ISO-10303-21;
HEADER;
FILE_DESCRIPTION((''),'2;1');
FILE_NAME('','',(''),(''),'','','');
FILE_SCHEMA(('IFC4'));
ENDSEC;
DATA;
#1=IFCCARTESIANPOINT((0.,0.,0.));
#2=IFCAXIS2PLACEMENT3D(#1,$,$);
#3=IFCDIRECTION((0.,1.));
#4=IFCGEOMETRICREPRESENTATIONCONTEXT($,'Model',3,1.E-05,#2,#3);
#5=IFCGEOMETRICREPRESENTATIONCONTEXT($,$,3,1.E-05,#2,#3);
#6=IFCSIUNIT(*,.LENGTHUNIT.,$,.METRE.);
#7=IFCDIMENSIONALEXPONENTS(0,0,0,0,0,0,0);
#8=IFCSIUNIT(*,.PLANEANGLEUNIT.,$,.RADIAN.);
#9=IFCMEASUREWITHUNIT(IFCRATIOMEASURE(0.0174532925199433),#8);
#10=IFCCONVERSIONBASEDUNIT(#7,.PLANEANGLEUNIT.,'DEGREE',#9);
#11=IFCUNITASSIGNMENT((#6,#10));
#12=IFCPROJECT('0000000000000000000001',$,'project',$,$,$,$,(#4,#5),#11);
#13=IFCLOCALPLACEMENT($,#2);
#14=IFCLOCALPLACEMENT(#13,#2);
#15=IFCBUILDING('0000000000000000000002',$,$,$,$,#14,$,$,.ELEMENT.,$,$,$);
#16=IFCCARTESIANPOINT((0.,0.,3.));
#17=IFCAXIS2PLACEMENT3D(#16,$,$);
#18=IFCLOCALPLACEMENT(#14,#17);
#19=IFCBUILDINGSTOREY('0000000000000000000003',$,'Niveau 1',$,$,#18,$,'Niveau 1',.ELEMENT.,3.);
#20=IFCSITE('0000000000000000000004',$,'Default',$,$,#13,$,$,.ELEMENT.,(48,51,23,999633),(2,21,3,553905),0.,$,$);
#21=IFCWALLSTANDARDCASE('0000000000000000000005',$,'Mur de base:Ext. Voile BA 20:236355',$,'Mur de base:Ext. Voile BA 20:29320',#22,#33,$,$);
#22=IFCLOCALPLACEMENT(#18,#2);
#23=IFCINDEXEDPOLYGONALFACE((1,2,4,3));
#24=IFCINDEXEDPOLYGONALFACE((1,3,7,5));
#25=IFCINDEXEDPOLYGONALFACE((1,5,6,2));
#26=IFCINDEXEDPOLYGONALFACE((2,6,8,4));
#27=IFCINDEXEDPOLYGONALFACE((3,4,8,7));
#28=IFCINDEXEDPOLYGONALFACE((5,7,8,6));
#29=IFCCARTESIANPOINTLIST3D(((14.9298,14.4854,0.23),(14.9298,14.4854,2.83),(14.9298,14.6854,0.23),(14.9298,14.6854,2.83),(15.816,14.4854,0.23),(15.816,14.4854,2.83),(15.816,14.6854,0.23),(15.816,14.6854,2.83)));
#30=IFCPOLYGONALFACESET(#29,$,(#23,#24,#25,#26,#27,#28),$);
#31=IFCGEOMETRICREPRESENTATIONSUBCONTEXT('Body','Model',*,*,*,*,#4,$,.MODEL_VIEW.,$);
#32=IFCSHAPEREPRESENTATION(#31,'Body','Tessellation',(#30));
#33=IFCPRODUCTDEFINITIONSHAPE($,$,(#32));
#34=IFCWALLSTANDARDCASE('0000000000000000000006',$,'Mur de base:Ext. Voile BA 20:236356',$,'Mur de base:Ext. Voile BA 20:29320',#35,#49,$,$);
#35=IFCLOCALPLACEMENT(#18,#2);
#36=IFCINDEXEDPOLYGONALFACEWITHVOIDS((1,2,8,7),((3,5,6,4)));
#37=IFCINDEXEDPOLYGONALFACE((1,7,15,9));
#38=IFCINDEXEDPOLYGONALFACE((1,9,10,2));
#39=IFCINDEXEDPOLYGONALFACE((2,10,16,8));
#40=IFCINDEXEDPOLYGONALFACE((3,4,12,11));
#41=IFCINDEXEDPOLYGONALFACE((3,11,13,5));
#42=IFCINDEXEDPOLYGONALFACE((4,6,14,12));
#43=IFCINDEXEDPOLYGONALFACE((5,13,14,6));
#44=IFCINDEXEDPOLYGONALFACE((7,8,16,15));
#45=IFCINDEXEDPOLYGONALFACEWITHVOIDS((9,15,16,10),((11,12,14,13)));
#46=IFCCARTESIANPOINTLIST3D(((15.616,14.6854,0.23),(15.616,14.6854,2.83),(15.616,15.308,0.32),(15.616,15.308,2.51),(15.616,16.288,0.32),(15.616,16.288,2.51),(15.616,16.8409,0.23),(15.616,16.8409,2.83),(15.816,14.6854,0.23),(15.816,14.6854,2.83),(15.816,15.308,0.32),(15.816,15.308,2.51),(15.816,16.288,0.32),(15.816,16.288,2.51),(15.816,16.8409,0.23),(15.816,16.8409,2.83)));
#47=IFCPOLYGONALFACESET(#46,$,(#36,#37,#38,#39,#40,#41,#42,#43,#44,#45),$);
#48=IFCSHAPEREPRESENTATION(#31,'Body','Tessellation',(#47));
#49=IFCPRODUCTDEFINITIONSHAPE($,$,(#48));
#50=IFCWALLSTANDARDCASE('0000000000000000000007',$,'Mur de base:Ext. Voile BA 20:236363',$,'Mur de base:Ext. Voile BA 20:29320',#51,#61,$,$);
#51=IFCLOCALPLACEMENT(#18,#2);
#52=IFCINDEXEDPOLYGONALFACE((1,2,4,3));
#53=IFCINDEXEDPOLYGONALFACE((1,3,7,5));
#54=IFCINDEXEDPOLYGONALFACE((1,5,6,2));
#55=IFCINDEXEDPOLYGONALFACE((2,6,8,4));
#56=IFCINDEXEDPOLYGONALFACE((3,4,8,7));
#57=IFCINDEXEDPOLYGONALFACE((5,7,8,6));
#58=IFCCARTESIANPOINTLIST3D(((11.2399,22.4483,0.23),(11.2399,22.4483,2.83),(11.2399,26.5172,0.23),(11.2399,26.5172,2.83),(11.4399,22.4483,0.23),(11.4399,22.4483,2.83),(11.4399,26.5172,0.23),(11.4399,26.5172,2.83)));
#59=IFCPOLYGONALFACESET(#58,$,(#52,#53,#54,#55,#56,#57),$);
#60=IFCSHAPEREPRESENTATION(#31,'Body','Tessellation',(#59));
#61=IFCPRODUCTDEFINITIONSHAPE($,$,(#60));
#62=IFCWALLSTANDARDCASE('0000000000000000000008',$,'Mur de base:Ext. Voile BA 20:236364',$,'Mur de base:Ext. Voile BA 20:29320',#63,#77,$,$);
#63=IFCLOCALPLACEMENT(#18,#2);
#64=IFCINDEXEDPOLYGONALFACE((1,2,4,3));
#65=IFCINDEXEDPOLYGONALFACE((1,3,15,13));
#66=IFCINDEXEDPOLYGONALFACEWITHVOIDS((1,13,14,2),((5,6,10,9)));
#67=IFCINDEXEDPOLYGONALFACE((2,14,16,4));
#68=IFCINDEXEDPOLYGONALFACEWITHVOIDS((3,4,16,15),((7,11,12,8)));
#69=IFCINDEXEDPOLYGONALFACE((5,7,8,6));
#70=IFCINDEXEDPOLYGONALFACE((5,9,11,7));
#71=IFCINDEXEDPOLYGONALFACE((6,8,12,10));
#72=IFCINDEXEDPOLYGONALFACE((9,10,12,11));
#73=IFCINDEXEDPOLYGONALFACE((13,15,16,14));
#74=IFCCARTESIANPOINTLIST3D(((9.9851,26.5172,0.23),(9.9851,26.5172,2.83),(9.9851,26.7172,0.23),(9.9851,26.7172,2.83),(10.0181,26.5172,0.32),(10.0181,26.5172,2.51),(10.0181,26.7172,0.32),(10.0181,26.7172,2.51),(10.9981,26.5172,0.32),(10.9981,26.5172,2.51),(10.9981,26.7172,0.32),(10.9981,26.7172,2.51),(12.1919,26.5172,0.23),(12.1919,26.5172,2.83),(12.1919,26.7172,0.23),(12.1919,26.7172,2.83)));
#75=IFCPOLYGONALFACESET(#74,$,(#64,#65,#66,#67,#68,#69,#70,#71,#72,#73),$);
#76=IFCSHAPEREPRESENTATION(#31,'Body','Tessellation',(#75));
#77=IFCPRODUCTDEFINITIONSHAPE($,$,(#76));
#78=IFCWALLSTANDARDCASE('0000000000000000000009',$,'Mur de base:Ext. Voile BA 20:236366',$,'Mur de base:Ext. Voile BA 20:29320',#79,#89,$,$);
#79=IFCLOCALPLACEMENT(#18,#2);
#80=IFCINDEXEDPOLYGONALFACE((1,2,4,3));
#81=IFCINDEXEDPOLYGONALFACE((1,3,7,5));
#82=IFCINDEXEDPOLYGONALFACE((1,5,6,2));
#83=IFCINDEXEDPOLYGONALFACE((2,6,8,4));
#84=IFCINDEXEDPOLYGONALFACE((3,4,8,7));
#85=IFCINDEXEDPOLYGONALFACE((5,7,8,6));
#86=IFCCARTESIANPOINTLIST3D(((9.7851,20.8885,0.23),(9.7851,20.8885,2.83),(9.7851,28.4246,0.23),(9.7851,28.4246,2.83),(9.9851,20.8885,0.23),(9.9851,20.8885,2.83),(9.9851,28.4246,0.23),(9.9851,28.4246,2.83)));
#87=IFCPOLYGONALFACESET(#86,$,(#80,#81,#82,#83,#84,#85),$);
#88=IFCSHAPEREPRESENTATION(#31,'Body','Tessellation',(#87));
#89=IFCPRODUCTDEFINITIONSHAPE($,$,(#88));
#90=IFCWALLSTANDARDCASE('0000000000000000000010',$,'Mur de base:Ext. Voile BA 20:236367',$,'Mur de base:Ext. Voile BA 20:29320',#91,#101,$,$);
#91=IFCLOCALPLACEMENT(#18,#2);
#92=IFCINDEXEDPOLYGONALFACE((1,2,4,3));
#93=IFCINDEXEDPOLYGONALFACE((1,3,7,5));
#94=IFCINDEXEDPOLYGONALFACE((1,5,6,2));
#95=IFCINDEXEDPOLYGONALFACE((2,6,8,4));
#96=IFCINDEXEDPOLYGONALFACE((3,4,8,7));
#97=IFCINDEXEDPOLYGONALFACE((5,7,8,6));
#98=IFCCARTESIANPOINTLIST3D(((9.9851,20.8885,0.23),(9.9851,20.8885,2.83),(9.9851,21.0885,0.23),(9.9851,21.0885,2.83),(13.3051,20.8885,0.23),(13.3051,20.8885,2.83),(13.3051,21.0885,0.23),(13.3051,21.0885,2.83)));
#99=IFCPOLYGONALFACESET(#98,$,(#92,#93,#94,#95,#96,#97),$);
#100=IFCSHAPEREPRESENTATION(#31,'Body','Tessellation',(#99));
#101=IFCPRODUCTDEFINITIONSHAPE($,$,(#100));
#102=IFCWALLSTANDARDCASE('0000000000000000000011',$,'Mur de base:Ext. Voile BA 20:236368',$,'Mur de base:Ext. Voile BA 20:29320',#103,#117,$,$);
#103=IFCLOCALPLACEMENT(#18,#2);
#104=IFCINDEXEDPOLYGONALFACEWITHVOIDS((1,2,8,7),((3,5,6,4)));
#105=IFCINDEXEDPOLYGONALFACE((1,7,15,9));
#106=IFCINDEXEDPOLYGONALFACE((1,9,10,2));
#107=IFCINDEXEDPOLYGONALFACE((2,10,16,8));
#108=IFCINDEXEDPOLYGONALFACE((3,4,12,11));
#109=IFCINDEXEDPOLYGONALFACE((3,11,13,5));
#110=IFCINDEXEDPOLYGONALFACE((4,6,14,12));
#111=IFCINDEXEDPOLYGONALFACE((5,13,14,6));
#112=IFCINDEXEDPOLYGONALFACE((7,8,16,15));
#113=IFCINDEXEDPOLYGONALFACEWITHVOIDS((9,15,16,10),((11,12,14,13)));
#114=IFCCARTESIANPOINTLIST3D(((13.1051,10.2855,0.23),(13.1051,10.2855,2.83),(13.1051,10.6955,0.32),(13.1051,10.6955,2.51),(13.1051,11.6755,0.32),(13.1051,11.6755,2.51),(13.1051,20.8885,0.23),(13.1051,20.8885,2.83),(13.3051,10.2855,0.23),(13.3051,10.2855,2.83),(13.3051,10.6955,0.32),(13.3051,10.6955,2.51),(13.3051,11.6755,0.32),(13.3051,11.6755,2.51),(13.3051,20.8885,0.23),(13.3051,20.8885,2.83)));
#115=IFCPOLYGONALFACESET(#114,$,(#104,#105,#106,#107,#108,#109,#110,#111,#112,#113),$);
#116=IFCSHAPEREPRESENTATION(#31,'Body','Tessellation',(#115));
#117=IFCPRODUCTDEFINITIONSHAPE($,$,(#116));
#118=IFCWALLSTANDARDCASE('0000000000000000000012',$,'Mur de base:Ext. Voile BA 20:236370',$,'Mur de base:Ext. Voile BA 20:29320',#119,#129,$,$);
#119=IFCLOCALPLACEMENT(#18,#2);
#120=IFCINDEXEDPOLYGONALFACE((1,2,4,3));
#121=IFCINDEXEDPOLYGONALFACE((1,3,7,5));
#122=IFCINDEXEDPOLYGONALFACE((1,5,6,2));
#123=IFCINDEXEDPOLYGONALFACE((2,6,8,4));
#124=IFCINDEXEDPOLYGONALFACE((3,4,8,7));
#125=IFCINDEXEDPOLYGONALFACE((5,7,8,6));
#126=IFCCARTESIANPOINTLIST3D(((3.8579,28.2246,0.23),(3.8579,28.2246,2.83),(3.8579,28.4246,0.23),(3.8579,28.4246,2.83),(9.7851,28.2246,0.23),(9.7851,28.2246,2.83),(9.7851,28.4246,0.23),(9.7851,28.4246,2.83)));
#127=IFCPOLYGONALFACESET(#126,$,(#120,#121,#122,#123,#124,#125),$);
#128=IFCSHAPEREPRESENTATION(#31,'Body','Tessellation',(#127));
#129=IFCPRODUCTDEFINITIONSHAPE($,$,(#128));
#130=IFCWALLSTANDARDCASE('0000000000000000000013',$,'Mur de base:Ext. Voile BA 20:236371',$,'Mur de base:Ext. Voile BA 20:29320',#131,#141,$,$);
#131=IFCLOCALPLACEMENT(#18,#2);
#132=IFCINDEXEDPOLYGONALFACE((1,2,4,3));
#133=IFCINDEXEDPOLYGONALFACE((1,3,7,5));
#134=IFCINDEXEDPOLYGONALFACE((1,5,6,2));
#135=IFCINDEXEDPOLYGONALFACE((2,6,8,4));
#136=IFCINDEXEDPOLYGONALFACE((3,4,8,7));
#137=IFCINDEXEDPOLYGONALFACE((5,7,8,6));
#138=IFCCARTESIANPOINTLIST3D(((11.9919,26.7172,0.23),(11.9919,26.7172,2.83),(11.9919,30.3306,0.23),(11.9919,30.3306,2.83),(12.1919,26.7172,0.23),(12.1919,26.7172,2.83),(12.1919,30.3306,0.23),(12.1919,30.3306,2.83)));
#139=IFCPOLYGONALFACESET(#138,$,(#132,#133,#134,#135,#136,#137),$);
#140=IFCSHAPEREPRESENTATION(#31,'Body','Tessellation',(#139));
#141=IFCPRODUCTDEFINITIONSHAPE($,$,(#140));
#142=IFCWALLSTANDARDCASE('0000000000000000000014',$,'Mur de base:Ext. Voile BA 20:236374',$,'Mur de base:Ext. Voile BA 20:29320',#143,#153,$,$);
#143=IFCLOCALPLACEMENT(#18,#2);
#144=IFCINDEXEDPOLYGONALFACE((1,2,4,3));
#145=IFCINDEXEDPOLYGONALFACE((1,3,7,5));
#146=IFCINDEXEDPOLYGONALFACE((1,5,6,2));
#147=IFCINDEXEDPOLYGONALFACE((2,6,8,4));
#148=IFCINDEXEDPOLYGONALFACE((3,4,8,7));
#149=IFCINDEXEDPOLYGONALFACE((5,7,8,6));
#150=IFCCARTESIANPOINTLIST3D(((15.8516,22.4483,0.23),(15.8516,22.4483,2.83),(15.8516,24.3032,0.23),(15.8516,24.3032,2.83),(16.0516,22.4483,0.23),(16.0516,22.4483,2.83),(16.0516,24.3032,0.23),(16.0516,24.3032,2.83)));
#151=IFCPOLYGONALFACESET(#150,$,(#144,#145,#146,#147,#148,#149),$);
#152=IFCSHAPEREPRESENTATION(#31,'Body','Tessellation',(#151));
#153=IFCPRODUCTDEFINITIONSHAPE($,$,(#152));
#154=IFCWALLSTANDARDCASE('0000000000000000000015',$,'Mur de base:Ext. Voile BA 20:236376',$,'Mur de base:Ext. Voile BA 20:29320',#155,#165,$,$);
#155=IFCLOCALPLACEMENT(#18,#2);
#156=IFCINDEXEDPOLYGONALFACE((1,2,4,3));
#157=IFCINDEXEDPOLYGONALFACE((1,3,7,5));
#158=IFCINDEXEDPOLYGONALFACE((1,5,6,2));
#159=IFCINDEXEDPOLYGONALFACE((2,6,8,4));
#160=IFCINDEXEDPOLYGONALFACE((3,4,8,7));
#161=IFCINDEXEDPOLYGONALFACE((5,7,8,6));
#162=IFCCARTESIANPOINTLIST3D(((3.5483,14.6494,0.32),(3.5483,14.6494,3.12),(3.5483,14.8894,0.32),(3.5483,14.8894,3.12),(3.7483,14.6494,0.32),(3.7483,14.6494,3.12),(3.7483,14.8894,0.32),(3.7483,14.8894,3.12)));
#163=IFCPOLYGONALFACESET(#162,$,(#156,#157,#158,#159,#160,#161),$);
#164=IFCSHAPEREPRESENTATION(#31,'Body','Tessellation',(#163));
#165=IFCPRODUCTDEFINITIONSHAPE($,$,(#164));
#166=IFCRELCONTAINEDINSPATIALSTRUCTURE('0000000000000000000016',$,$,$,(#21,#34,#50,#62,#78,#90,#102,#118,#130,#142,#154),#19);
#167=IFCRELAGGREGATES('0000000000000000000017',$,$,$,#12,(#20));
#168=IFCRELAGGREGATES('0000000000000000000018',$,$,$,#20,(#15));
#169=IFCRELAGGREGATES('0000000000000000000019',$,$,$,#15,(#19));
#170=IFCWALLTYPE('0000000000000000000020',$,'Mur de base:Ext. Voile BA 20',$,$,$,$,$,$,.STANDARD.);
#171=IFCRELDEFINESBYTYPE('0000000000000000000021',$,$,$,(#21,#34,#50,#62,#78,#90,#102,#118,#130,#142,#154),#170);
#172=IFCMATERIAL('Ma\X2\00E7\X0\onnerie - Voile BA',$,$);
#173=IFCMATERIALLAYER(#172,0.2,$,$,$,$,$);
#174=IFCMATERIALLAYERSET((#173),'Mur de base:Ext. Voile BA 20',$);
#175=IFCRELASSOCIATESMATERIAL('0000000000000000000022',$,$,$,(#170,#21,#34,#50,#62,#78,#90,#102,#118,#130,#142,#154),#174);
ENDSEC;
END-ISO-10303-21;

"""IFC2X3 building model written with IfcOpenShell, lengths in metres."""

from ifc_helpers import new_model, entity, si_unit, converted_unit, direction, frame, frame_2d, origin, place, context, subcontext, project, spatial, rectangle, extrude, material, layer, layer_set, layer_usage, type_object, element, save


model = new_model("IFC2X3")

# Units and contexts
model_context = context("Model", 3, precision=1e-05, world=origin(), true_north=direction((0.0, 1.0)))
context_of_model = context(None, 3, precision=1e-05, world=origin(), true_north=direction((0.0, 1.0)))
body_context = subcontext(model_context, "Body", "Model", "MODEL_VIEW")
ifc_project = project(units=[si_unit("LENGTHUNIT", "METRE"), converted_unit("PLANEANGLEUNIT", "DEGREE", entity("IfcRatioMeasure", 0.0174532925199433), si_unit("PLANEANGLEUNIT", "RADIAN"), dimensions=[0, 0, 0, 0, 0, 0, 0])], contexts=[model_context, context_of_model])

# Site, building, storey
site_placement = place(None, origin())
site = spatial("IfcSite", under=ifc_project, at=site_placement, Name="Default", CompositionType="ELEMENT", RefLatitude=(48, 51, 23, 999633), RefLongitude=(2, 21, 3, 553905), RefElevation=0.0)
building_placement = place(site_placement, origin())
building = spatial("IfcBuilding", under=site, at=building_placement, CompositionType="ELEMENT")
storey_placement = place(building_placement, frame((0.0, 0.0, 3.0)))
storey = spatial("IfcBuildingStorey", under=building, at=storey_placement, Name="Niveau 1", LongName="Niveau 1", CompositionType="ELEMENT", Elevation=3.0)

# Wall
ifc_material = material(Name="Maçonnerie - Voile BA")
ifc_layer_1 = layer(ifc_material, 0.2)
ifc_layer_set_1 = layer_set([ifc_layer_1], Name="Mur de base:Ext. Voile BA 20")
ifc_layer_usage_1 = layer_usage(ifc_layer_set_1, "AXIS2", "NEGATIVE", 0.1)
wall_type_1 = type_object("IfcWallType", Name="Mur de base:Ext. Voile BA 20", PredefinedType="STANDARD", material=ifc_layer_set_1)
wall_1_placement = place(storey_placement, frame((14.9298, 14.5854, 0.23)))
element("IfcWallStandardCase", 1, at=wall_1_placement, inside=storey, type_object=wall_type_1, material=ifc_layer_usage_1, Name="Mur de base:Ext. Voile BA 20:236355", ObjectType="Mur de base:Ext. Voile BA 20:29320", context=body_context, shape_type="SweptSolid", body=[
    extrude(rectangle(XDim=0.8862, YDim=0.2, at=frame_2d((0.4431, 0.0), x_axis=(-1.0, 0.0))), origin(), (0.0, 0.0, 1.0), 2.6),
])

# Wall, opening
ifc_layer_usage_2 = layer_usage(ifc_layer_set_1, "AXIS2", "NEGATIVE", 0.1)
wall_2_placement = place(storey_placement, frame((15.716, 14.6854, 0.23), z_axis=(0.0, 0.0, 1.0), x_axis=(0.0, 1.0, 0.0)))
wall_2 = element("IfcWallStandardCase", 2, at=wall_2_placement, inside=storey, type_object=wall_type_1, material=ifc_layer_usage_2, Name="Mur de base:Ext. Voile BA 20:236356", ObjectType="Mur de base:Ext. Voile BA 20:29320", context=body_context, shape_type="SweptSolid", body=[
    extrude(rectangle(XDim=2.1555, YDim=0.2, at=frame_2d((1.0778, 0.0), x_axis=(-1.0, 0.0))), origin(), (0.0, 0.0, 1.0), 2.6),
])
opening_1_placement = place(wall_2_placement, origin())
element("IfcOpeningElement", 3, at=opening_1_placement, cuts=wall_2, ObjectType="Opening", context=body_context, shape_type="SweptSolid", body=[
    extrude(rectangle(XDim=2.19, YDim=0.98, at=frame_2d((0.0, 0.0), x_axis=(1.0, 0.0))), frame((1.1126, -0.1, 1.185), z_axis=(0.0, 1.0, 0.0), x_axis=(0.0, 0.0, -1.0)), (0.0, 0.0, 1.0), 0.2),
])

# Wall
ifc_layer_usage_3 = layer_usage(ifc_layer_set_1, "AXIS2", "NEGATIVE", 0.1)
wall_3_placement = place(storey_placement, frame((11.3399, 22.4483, 0.23), z_axis=(0.0, 0.0, 1.0), x_axis=(0.0, 1.0, 0.0)))
element("IfcWallStandardCase", 4, at=wall_3_placement, inside=storey, type_object=wall_type_1, material=ifc_layer_usage_3, Name="Mur de base:Ext. Voile BA 20:236363", ObjectType="Mur de base:Ext. Voile BA 20:29320", context=body_context, shape_type="SweptSolid", body=[
    extrude(rectangle(XDim=4.0689, YDim=0.2, at=frame_2d((2.0344, 0.0), x_axis=(-1.0, 0.0))), origin(), (0.0, 0.0, 1.0), 2.6),
])

# Wall, opening
ifc_layer_usage_4 = layer_usage(ifc_layer_set_1, "AXIS2", "NEGATIVE", 0.1)
wall_4_placement = place(storey_placement, frame((12.1919, 26.6172, 0.23), z_axis=(0.0, 0.0, 1.0), x_axis=(-1.0, 0.0, 0.0)))
wall_4 = element("IfcWallStandardCase", 5, at=wall_4_placement, inside=storey, type_object=wall_type_1, material=ifc_layer_usage_4, Name="Mur de base:Ext. Voile BA 20:236364", ObjectType="Mur de base:Ext. Voile BA 20:29320", context=body_context, shape_type="SweptSolid", body=[
    extrude(rectangle(XDim=2.2068, YDim=0.2, at=frame_2d((1.1034, 0.0), x_axis=(-1.0, 0.0))), origin(), (0.0, 0.0, 1.0), 2.6),
])
opening_2_placement = place(wall_4_placement, origin())
element("IfcOpeningElement", 6, at=opening_2_placement, cuts=wall_4, ObjectType="Opening", context=body_context, shape_type="SweptSolid", body=[
    extrude(rectangle(XDim=2.19, YDim=0.98, at=frame_2d((0.0, 0.0), x_axis=(1.0, 0.0))), frame((1.6838, -0.1, 1.185), z_axis=(0.0, 1.0, 0.0), x_axis=(0.0, 0.0, -1.0)), (0.0, 0.0, 1.0), 0.2),
])

# Walls
ifc_layer_usage_5 = layer_usage(ifc_layer_set_1, "AXIS2", "NEGATIVE", 0.1)
wall_5_placement = place(storey_placement, frame((9.8851, 28.4246, 0.23), z_axis=(0.0, 0.0, 1.0), x_axis=(0.0, -1.0, 0.0)))
element("IfcWallStandardCase", 7, at=wall_5_placement, inside=storey, type_object=wall_type_1, material=ifc_layer_usage_5, Name="Mur de base:Ext. Voile BA 20:236366", ObjectType="Mur de base:Ext. Voile BA 20:29320", context=body_context, shape_type="SweptSolid", body=[
    extrude(rectangle(XDim=7.5361, YDim=0.2, at=frame_2d((3.7681, 0.0), x_axis=(-1.0, 0.0))), origin(), (0.0, 0.0, 1.0), 2.6),
])
ifc_layer_usage_6 = layer_usage(ifc_layer_set_1, "AXIS2", "NEGATIVE", 0.1)
wall_6_placement = place(storey_placement, frame((9.9851, 20.9885, 0.23)))
element("IfcWallStandardCase", 8, at=wall_6_placement, inside=storey, type_object=wall_type_1, material=ifc_layer_usage_6, Name="Mur de base:Ext. Voile BA 20:236367", ObjectType="Mur de base:Ext. Voile BA 20:29320", context=body_context, shape_type="SweptSolid", body=[
    extrude(rectangle(XDim=3.32, YDim=0.2, at=frame_2d((1.66, 0.0), x_axis=(-1.0, 0.0))), origin(), (0.0, 0.0, 1.0), 2.6),
])

# Wall, opening
ifc_layer_usage_7 = layer_usage(ifc_layer_set_1, "AXIS2", "NEGATIVE", 0.1)
wall_7_placement = place(storey_placement, frame((13.2051, 20.8885, 0.23), z_axis=(0.0, 0.0, 1.0), x_axis=(0.0, -1.0, 0.0)))
wall_7 = element("IfcWallStandardCase", 9, at=wall_7_placement, inside=storey, type_object=wall_type_1, material=ifc_layer_usage_7, Name="Mur de base:Ext. Voile BA 20:236368", ObjectType="Mur de base:Ext. Voile BA 20:29320", context=body_context, shape_type="SweptSolid", body=[
    extrude(rectangle(XDim=10.603, YDim=0.2, at=frame_2d((5.3015, 0.0), x_axis=(-1.0, 0.0))), origin(), (0.0, 0.0, 1.0), 2.6),
])
opening_3_placement = place(wall_7_placement, origin())
element("IfcOpeningElement", 10, at=opening_3_placement, cuts=wall_7, ObjectType="Opening", context=body_context, shape_type="SweptSolid", body=[
    extrude(rectangle(XDim=2.19, YDim=0.98, at=frame_2d((0.0, 0.0), x_axis=(1.0, 0.0))), frame((9.703, -0.1, 1.185), z_axis=(0.0, 1.0, 0.0), x_axis=(0.0, 0.0, -1.0)), (0.0, 0.0, 1.0), 0.2),
])

# Walls
ifc_layer_usage_8 = layer_usage(ifc_layer_set_1, "AXIS2", "NEGATIVE", 0.1)
wall_8_placement = place(storey_placement, frame((9.7851, 28.3246, 0.23), z_axis=(0.0, 0.0, 1.0), x_axis=(-1.0, 0.0, 0.0)))
element("IfcWallStandardCase", 11, at=wall_8_placement, inside=storey, type_object=wall_type_1, material=ifc_layer_usage_8, Name="Mur de base:Ext. Voile BA 20:236370", ObjectType="Mur de base:Ext. Voile BA 20:29320", context=body_context, shape_type="SweptSolid", body=[
    extrude(rectangle(XDim=5.9272, YDim=0.2, at=frame_2d((2.9636, 0.0), x_axis=(-1.0, 0.0))), origin(), (0.0, 0.0, 1.0), 2.6),
])
ifc_layer_usage_9 = layer_usage(ifc_layer_set_1, "AXIS2", "NEGATIVE", 0.1)
wall_9_placement = place(storey_placement, frame((12.0919, 26.7172, 0.23), z_axis=(0.0, 0.0, 1.0), x_axis=(0.0, 1.0, 0.0)))
element("IfcWallStandardCase", 12, at=wall_9_placement, inside=storey, type_object=wall_type_1, material=ifc_layer_usage_9, Name="Mur de base:Ext. Voile BA 20:236371", ObjectType="Mur de base:Ext. Voile BA 20:29320", context=body_context, shape_type="SweptSolid", body=[
    extrude(rectangle(XDim=3.6135, YDim=0.2, at=frame_2d((1.8067, 0.0), x_axis=(-1.0, 0.0))), origin(), (0.0, 0.0, 1.0), 2.6),
])
ifc_layer_usage_10 = layer_usage(ifc_layer_set_1, "AXIS2", "NEGATIVE", 0.1)
wall_10_placement = place(storey_placement, frame((15.9516, 24.3032, 0.23), z_axis=(0.0, 0.0, 1.0), x_axis=(0.0, -1.0, 0.0)))
element("IfcWallStandardCase", 13, at=wall_10_placement, inside=storey, type_object=wall_type_1, material=ifc_layer_usage_10, Name="Mur de base:Ext. Voile BA 20:236374", ObjectType="Mur de base:Ext. Voile BA 20:29320", context=body_context, shape_type="SweptSolid", body=[
    extrude(rectangle(XDim=1.8549, YDim=0.2, at=frame_2d((0.9274, 0.0), x_axis=(-1.0, 0.0))), origin(), (0.0, 0.0, 1.0), 2.6),
])
ifc_layer_usage_11 = layer_usage(ifc_layer_set_1, "AXIS2", "NEGATIVE", 0.1)
wall_11_placement = place(storey_placement, frame((3.6483, 14.6494, 0.32), z_axis=(0.0, 0.0, 1.0), x_axis=(0.0, 1.0, 0.0)))
element("IfcWallStandardCase", 14, at=wall_11_placement, inside=storey, type_object=wall_type_1, material=ifc_layer_usage_11, Name="Mur de base:Ext. Voile BA 20:236376", ObjectType="Mur de base:Ext. Voile BA 20:29320", context=body_context, shape_type="SweptSolid", body=[
    extrude(rectangle(XDim=0.24, YDim=0.2, at=frame_2d((0.12, 0.0), x_axis=(-1.0, 0.0))), origin(), (0.0, 0.0, 1.0), 2.8),
])

save(model, "model.ifc")
